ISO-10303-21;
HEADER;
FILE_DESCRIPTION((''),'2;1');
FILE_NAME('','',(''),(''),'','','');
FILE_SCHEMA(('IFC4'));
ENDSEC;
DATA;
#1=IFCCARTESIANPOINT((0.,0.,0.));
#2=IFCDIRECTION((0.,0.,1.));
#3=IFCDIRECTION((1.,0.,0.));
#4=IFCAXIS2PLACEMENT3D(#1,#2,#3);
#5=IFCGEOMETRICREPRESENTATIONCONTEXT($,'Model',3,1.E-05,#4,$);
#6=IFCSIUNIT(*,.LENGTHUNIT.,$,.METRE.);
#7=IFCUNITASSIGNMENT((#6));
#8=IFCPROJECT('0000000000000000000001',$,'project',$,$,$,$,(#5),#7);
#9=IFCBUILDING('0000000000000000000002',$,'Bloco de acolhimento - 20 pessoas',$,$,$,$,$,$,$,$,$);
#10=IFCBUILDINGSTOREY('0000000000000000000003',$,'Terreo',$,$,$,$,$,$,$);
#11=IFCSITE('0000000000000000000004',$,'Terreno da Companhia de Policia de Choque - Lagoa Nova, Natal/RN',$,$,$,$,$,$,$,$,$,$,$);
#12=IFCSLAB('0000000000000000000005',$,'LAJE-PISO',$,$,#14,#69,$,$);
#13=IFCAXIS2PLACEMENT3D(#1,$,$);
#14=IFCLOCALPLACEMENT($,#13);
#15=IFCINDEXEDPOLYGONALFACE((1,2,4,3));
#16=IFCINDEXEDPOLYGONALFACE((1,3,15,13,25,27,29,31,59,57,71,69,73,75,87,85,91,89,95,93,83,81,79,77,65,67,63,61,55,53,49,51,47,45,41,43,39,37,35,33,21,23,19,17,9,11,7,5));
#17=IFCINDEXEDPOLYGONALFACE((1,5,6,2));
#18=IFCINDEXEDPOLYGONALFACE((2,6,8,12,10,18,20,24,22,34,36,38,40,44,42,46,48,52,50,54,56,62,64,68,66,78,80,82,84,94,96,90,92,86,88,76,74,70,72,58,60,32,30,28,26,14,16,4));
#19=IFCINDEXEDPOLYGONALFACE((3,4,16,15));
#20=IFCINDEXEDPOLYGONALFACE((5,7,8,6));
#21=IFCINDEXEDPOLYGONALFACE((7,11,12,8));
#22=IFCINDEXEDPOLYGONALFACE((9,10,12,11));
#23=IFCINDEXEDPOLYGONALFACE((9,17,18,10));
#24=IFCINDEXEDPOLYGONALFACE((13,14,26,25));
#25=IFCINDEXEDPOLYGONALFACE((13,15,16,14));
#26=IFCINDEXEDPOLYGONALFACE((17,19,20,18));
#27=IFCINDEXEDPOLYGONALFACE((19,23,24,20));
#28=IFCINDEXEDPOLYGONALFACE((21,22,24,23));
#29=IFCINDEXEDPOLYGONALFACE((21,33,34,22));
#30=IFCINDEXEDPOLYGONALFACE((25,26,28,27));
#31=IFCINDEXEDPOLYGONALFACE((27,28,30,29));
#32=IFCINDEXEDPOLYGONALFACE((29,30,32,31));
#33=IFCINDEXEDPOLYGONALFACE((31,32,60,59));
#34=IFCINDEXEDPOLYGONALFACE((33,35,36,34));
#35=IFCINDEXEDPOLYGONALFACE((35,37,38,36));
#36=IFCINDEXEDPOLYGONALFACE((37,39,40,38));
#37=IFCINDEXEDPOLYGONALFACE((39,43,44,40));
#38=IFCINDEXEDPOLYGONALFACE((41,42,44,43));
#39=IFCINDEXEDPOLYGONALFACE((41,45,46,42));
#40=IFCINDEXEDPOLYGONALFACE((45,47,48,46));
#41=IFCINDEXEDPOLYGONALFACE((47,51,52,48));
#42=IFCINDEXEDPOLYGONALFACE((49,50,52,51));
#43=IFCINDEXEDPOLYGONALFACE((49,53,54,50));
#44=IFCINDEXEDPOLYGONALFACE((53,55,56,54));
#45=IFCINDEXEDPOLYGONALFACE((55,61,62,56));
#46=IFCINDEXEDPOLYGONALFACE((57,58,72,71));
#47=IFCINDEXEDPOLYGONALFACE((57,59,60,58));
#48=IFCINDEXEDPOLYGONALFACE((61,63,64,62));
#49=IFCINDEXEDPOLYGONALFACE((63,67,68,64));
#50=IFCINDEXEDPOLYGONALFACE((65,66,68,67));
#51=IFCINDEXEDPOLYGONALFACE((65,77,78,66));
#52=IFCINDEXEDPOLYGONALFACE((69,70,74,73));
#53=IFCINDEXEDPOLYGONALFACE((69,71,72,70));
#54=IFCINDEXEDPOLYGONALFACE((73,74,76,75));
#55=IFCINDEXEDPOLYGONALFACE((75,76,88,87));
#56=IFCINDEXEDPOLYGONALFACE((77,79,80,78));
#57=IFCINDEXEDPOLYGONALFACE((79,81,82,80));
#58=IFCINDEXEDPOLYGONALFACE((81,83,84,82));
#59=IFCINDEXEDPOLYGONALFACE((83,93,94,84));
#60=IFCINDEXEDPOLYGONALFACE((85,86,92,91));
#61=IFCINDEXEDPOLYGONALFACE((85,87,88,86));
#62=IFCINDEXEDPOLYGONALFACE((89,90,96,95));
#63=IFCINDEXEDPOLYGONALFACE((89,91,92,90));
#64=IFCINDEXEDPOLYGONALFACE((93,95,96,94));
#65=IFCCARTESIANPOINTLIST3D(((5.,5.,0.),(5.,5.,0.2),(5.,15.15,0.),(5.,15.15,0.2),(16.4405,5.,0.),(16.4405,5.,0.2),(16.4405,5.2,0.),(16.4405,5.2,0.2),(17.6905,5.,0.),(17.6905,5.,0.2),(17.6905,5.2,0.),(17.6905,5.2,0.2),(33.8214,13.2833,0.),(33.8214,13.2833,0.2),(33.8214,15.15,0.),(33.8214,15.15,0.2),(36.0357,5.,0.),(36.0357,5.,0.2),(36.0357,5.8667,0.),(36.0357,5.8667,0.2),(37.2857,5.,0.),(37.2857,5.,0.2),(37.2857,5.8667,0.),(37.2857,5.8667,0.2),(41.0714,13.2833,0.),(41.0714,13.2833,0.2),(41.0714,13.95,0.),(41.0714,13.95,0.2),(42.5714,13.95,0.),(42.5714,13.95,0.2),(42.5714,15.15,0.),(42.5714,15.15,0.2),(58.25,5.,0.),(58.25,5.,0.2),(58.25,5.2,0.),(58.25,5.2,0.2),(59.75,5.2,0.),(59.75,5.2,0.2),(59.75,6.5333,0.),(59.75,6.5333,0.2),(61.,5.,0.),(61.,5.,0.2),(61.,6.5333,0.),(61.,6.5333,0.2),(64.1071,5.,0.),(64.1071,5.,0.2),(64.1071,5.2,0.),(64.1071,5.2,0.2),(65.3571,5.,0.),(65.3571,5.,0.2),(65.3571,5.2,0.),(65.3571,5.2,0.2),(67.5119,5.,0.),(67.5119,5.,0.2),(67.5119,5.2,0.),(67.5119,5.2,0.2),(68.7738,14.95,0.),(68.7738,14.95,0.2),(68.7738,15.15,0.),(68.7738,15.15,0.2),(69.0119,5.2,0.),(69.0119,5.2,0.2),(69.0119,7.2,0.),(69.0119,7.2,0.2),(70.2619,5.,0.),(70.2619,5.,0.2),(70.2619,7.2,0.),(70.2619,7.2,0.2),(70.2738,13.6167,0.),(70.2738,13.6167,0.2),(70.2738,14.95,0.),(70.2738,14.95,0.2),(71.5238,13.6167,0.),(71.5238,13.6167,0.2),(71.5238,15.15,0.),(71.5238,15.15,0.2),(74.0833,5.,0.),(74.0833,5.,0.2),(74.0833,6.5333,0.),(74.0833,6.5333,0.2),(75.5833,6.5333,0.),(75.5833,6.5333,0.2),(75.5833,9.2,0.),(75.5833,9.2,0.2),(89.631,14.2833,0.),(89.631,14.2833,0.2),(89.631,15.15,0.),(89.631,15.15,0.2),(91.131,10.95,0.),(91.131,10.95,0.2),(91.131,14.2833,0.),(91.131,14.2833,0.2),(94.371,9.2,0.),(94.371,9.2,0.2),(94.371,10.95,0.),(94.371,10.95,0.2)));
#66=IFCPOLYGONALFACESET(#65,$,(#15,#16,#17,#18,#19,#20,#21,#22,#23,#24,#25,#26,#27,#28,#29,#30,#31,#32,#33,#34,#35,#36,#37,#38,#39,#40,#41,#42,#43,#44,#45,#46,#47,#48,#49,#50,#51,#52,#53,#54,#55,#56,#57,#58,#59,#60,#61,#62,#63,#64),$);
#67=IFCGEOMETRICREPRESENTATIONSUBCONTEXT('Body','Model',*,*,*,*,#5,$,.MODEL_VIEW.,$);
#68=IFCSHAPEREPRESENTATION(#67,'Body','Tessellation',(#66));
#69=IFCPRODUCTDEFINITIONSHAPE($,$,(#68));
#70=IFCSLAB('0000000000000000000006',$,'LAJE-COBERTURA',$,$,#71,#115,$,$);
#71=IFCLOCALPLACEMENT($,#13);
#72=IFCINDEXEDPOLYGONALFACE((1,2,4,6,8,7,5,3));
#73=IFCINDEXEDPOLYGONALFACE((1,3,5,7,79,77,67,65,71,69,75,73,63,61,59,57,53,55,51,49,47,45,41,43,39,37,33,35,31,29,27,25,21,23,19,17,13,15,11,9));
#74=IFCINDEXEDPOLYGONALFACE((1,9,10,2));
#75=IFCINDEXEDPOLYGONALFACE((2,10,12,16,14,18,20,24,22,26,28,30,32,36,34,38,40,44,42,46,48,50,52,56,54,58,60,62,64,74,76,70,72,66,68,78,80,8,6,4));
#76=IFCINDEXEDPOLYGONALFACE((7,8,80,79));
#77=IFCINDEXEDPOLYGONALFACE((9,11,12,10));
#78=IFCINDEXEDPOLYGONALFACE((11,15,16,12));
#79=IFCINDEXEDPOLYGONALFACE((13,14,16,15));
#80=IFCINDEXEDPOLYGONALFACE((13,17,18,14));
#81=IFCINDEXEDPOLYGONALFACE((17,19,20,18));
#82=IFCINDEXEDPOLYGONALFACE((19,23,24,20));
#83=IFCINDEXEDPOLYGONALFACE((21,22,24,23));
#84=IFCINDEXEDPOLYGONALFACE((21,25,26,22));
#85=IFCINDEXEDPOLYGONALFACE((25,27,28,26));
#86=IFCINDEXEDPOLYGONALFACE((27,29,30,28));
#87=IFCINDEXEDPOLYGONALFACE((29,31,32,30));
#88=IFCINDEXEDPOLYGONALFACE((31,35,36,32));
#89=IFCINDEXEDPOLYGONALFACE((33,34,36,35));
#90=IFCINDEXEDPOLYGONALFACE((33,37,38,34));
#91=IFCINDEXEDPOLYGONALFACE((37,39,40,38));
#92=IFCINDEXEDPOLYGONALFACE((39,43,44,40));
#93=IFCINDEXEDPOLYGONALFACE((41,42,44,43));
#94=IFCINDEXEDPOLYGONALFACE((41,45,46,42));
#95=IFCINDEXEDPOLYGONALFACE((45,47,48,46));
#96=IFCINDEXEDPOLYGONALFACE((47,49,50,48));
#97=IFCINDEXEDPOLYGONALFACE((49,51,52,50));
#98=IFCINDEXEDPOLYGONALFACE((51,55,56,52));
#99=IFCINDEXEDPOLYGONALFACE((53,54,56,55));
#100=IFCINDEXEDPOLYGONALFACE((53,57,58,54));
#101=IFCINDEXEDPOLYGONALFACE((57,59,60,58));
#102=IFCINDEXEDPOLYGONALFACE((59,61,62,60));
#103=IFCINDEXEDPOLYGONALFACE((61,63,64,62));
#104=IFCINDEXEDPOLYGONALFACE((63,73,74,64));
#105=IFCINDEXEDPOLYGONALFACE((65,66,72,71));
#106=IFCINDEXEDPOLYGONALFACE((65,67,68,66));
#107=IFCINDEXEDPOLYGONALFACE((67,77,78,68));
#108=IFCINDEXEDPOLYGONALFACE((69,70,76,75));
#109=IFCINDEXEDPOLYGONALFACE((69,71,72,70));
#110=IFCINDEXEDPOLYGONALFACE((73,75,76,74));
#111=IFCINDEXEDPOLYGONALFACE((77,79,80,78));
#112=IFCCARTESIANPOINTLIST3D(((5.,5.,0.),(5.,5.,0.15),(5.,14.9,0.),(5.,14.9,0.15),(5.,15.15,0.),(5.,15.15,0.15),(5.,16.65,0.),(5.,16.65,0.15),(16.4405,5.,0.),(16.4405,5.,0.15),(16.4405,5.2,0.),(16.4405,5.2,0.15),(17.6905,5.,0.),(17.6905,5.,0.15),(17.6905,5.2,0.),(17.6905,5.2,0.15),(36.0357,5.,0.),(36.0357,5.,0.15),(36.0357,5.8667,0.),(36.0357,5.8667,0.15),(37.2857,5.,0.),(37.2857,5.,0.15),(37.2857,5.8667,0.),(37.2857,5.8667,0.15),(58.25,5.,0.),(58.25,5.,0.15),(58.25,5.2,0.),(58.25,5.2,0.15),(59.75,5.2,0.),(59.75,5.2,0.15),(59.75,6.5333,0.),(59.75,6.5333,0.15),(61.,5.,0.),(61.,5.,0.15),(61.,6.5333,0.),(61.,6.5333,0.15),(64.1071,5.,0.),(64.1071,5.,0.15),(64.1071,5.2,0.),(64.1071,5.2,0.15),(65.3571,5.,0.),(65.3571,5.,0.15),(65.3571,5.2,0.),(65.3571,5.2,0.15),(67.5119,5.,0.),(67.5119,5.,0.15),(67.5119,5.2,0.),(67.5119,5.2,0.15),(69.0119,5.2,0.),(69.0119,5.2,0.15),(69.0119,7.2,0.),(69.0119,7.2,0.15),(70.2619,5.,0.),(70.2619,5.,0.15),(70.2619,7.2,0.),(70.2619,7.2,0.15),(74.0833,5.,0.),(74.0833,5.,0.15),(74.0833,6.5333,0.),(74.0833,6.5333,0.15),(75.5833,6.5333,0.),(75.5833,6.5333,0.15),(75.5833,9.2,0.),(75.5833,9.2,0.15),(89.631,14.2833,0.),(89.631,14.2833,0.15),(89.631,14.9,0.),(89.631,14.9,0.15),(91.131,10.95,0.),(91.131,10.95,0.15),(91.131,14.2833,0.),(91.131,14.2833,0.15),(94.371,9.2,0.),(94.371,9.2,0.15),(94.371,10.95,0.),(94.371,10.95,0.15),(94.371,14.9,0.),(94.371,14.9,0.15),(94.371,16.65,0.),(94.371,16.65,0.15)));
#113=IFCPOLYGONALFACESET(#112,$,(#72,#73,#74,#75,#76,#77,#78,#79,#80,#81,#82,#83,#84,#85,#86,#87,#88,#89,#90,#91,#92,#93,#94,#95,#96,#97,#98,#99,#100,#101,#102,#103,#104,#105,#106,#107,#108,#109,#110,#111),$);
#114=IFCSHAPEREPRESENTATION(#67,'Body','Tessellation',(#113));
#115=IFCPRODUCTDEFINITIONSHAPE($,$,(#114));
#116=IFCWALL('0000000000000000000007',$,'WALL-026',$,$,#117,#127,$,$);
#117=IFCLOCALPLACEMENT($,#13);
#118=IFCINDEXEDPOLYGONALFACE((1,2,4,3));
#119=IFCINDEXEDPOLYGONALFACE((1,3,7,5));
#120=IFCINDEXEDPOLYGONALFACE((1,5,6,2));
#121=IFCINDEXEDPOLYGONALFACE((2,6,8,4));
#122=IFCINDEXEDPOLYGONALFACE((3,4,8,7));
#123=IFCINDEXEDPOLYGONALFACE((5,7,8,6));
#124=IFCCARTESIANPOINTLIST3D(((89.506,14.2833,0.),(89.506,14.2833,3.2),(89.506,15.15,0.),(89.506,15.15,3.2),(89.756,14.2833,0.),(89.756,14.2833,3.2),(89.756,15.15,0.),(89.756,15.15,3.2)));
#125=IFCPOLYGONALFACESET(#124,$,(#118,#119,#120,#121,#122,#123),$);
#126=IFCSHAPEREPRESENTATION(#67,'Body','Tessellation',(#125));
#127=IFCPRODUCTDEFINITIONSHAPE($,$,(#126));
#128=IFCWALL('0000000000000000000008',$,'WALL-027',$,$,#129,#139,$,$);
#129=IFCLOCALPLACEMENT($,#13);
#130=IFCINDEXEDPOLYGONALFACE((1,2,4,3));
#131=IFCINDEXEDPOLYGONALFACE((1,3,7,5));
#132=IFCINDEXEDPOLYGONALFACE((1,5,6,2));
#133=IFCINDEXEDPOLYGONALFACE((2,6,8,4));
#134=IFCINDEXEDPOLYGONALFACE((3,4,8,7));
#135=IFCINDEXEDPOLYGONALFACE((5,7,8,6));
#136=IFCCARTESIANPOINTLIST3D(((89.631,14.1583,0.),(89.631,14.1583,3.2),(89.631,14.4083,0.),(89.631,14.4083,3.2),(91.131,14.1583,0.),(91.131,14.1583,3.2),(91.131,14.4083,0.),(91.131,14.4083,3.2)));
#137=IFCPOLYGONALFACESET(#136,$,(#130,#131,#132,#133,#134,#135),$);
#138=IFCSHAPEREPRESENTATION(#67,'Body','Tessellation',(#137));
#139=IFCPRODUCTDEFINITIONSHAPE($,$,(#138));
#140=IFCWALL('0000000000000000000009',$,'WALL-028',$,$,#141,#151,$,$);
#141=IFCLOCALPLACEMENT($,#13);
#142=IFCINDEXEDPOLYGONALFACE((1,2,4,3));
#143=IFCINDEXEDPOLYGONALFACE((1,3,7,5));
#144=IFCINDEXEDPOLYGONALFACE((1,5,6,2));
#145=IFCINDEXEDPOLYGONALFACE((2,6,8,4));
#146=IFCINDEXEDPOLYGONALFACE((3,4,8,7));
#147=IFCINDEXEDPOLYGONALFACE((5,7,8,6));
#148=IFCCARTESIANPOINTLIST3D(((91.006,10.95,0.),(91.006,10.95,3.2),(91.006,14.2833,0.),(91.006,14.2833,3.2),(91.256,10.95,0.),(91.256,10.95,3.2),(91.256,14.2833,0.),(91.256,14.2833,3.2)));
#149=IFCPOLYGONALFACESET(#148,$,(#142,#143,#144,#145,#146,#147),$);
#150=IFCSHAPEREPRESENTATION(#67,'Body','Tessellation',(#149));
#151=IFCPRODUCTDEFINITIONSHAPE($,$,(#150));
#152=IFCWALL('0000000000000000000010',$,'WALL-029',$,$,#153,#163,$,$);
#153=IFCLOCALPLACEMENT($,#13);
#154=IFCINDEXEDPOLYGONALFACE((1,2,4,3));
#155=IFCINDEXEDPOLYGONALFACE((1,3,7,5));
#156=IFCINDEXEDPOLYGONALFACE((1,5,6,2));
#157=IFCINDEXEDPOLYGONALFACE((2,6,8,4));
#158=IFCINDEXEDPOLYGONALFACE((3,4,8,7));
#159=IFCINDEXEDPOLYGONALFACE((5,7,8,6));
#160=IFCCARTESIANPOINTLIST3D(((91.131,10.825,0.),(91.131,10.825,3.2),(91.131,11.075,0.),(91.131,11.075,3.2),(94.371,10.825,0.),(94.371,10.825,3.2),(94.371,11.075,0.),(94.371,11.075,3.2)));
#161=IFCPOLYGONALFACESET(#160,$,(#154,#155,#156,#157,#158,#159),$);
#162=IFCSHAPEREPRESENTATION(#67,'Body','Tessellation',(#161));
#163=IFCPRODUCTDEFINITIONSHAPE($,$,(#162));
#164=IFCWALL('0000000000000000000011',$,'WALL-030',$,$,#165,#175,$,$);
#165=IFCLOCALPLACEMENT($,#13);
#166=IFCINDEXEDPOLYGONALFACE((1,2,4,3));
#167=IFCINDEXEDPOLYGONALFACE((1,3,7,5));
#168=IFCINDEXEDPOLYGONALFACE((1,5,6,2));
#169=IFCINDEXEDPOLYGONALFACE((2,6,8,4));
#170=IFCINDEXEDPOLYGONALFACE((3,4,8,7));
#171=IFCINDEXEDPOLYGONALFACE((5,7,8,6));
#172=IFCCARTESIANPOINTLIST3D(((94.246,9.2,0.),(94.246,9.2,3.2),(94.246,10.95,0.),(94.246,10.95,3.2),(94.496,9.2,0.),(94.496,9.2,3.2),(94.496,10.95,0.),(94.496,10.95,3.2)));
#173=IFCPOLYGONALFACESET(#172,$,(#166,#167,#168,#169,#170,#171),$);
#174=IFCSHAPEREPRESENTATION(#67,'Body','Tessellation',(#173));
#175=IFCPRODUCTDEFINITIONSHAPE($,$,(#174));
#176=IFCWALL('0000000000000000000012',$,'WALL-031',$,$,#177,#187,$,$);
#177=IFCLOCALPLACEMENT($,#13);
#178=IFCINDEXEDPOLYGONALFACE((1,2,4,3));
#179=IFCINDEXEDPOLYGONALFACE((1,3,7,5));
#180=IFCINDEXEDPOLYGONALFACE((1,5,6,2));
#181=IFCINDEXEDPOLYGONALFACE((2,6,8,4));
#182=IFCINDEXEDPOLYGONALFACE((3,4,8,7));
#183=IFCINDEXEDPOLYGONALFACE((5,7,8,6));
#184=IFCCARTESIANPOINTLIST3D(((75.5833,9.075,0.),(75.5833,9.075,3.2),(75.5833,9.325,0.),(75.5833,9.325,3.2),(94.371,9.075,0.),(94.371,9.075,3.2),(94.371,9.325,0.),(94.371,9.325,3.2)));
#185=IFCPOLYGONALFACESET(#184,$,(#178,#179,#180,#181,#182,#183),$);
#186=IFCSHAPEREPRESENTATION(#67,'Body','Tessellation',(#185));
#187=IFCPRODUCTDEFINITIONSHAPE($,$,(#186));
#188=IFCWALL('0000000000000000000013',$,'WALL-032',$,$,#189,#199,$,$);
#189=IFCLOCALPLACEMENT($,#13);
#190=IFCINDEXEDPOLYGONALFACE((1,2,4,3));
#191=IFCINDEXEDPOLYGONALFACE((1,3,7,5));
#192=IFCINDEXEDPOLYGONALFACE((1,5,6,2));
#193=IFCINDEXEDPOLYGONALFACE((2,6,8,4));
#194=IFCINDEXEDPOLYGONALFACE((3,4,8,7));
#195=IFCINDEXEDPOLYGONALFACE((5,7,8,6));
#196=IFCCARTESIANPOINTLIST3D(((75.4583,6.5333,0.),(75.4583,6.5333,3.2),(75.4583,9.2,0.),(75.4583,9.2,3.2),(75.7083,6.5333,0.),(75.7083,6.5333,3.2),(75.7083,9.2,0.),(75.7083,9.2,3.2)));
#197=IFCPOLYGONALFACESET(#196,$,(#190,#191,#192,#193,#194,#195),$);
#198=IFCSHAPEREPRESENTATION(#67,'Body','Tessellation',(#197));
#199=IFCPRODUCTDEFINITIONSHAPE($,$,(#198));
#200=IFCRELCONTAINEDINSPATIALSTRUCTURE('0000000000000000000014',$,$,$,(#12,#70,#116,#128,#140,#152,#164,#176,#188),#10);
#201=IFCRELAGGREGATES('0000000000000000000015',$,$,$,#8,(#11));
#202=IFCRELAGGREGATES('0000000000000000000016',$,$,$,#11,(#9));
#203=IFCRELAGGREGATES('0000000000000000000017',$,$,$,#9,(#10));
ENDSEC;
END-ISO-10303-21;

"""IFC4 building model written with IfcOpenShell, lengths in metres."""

from ifc_helpers import new_model, si_unit, origin_with_axes, place, context, subcontext, project, spatial, polyline, outline, extrude, element, save


model = new_model("IFC4")

# Units and contexts
model_context = context("Model", 3, precision=1e-05, world=origin_with_axes())
body_context = subcontext(model_context, "Body", "Model", "MODEL_VIEW")
ifc_project = project(units=[si_unit("LENGTHUNIT", "METRE")], contexts=[model_context])

# Site, building, storey
site = spatial("IfcSite", under=ifc_project, Name="Terreno da Companhia de Policia de Choque - Lagoa Nova, Natal/RN")
building = spatial("IfcBuilding", under=site, Name="Bloco de acolhimento - 20 pessoas")
storey = spatial("IfcBuildingStorey", under=building, Name="Terreo")

# Slabs
slab_1_placement = place(None, origin_with_axes())
element("IfcSlab", 1, at=slab_1_placement, inside=storey, Name="LAJE-PISO", context=body_context, shape_type="SweptSolid", body=[
    extrude(outline(polyline([(59.75, 5.2, 0.0), (58.25, 5.2, 0.0), (58.25, 5.0, 0.0), (37.2857, 5.0, 0.0), (37.2857, 5.8667, 0.0), (36.0357, 5.8667, 0.0), (36.0357, 5.0, 0.0), (17.6905, 5.0, 0.0), (17.6905, 5.2, 0.0), (16.4405, 5.2, 0.0), (16.4405, 5.0, 0.0), (5.0, 5.0, 0.0), (5.0, 15.15, 0.0), (33.8214, 15.15, 0.0), (33.8214, 13.2833, 0.0), (41.0714, 13.2833, 0.0), (41.0714, 13.95, 0.0), (42.5714, 13.95, 0.0), (42.5714, 15.15, 0.0), (68.7738, 15.15, 0.0), (68.7738, 14.95, 0.0), (70.2738, 14.95, 0.0), (70.2738, 13.6167, 0.0), (71.5238, 13.6167, 0.0), (71.5238, 15.15, 0.0), (89.631, 15.15, 0.0), (89.631, 14.2833, 0.0), (91.131, 14.2833, 0.0), (91.131, 10.95, 0.0), (94.371, 10.95, 0.0), (94.371, 9.2, 0.0), (75.5833, 9.2, 0.0), (75.5833, 6.5333, 0.0), (74.0833, 6.5333, 0.0), (74.0833, 5.0, 0.0), (70.2619, 5.0, 0.0), (70.2619, 7.2, 0.0), (69.0119, 7.2, 0.0), (69.0119, 5.2, 0.0), (67.5119, 5.2, 0.0), (67.5119, 5.0, 0.0), (65.3571, 5.0, 0.0), (65.3571, 5.2, 0.0), (64.1071, 5.2, 0.0), (64.1071, 5.0, 0.0), (61.0, 5.0, 0.0), (61.0, 6.5333, 0.0), (59.75, 6.5333, 0.0), (59.75, 5.2, 0.0)])), None, (0.0, 0.0, 1.0), 0.2),
])
slab_2_placement = place(None, origin_with_axes())
element("IfcSlab", 2, at=slab_2_placement, inside=storey, Name="LAJE-COBERTURA", context=body_context, shape_type="SweptSolid", body=[
    extrude(outline(polyline([(5.0, 14.9, 0.0), (5.0, 15.15, 0.0), (5.0, 16.65, 0.0), (94.371, 16.65, 0.0), (94.371, 14.9, 0.0), (89.631, 14.9, 0.0), (89.631, 14.2833, 0.0), (91.131, 14.2833, 0.0), (91.131, 10.95, 0.0), (94.371, 10.95, 0.0), (94.371, 9.2, 0.0), (75.5833, 9.2, 0.0), (75.5833, 6.5333, 0.0), (74.0833, 6.5333, 0.0), (74.0833, 5.0, 0.0), (70.2619, 5.0, 0.0), (70.2619, 7.2, 0.0), (69.0119, 7.2, 0.0), (69.0119, 5.2, 0.0), (67.5119, 5.2, 0.0), (67.5119, 5.0, 0.0), (65.3571, 5.0, 0.0), (65.3571, 5.2, 0.0), (64.1071, 5.2, 0.0), (64.1071, 5.0, 0.0), (61.0, 5.0, 0.0), (61.0, 6.5333, 0.0), (59.75, 6.5333, 0.0), (59.75, 5.2, 0.0), (58.25, 5.2, 0.0), (58.25, 5.0, 0.0), (37.2857, 5.0, 0.0), (37.2857, 5.8667, 0.0), (36.0357, 5.8667, 0.0), (36.0357, 5.0, 0.0), (17.6905, 5.0, 0.0), (17.6905, 5.2, 0.0), (16.4405, 5.2, 0.0), (16.4405, 5.0, 0.0), (5.0, 5.0, 0.0), (5.0, 14.9, 0.0)])), None, (0.0, 0.0, 1.0), 0.15),
])

# Walls
wall_1_placement = place(None, origin_with_axes())
element("IfcWall", 3, at=wall_1_placement, inside=storey, Name="WALL-026", context=body_context, shape_type="SweptSolid", body=[
    extrude(outline(polyline([(89.756, 14.2833, 0.0), (89.756, 15.15, 0.0), (89.506, 15.15, 0.0), (89.506, 14.2833, 0.0), (89.756, 14.2833, 0.0)])), None, (0.0, 0.0, 1.0), 3.2),
])
wall_2_placement = place(None, origin_with_axes())
element("IfcWall", 4, at=wall_2_placement, inside=storey, Name="WALL-027", context=body_context, shape_type="SweptSolid", body=[
    extrude(outline(polyline([(91.131, 14.1583, 0.0), (91.131, 14.4083, 0.0), (89.631, 14.4083, 0.0), (89.631, 14.1583, 0.0), (91.131, 14.1583, 0.0)])), None, (0.0, 0.0, 1.0), 3.2),
])
wall_3_placement = place(None, origin_with_axes())
element("IfcWall", 5, at=wall_3_placement, inside=storey, Name="WALL-028", context=body_context, shape_type="SweptSolid", body=[
    extrude(outline(polyline([(91.256, 10.95, 0.0), (91.256, 14.2833, 0.0), (91.006, 14.2833, 0.0), (91.006, 10.95, 0.0), (91.256, 10.95, 0.0)])), None, (0.0, 0.0, 1.0), 3.2),
])
wall_4_placement = place(None, origin_with_axes())
element("IfcWall", 6, at=wall_4_placement, inside=storey, Name="WALL-029", context=body_context, shape_type="SweptSolid", body=[
    extrude(outline(polyline([(94.371, 10.825, 0.0), (94.371, 11.075, 0.0), (91.131, 11.075, 0.0), (91.131, 10.825, 0.0), (94.371, 10.825, 0.0)])), None, (0.0, 0.0, 1.0), 3.2),
])
wall_5_placement = place(None, origin_with_axes())
element("IfcWall", 7, at=wall_5_placement, inside=storey, Name="WALL-030", context=body_context, shape_type="SweptSolid", body=[
    extrude(outline(polyline([(94.496, 9.2, 0.0), (94.496, 10.95, 0.0), (94.246, 10.95, 0.0), (94.246, 9.2, 0.0), (94.496, 9.2, 0.0)])), None, (0.0, 0.0, 1.0), 3.2),
])
wall_6_placement = place(None, origin_with_axes())
element("IfcWall", 8, at=wall_6_placement, inside=storey, Name="WALL-031", context=body_context, shape_type="SweptSolid", body=[
    extrude(outline(polyline([(94.371, 9.075, 0.0), (94.371, 9.325, 0.0), (75.5833, 9.325, 0.0), (75.5833, 9.075, 0.0), (94.371, 9.075, 0.0)])), None, (0.0, 0.0, 1.0), 3.2),
])
wall_7_placement = place(None, origin_with_axes())
element("IfcWall", 9, at=wall_7_placement, inside=storey, Name="WALL-032", context=body_context, shape_type="SweptSolid", body=[
    extrude(outline(polyline([(75.7083, 6.5333, 0.0), (75.7083, 9.2, 0.0), (75.4583, 9.2, 0.0), (75.4583, 6.5333, 0.0), (75.7083, 6.5333, 0.0)])), None, (0.0, 0.0, 1.0), 3.2),
])

save(model, "model.ifc")
